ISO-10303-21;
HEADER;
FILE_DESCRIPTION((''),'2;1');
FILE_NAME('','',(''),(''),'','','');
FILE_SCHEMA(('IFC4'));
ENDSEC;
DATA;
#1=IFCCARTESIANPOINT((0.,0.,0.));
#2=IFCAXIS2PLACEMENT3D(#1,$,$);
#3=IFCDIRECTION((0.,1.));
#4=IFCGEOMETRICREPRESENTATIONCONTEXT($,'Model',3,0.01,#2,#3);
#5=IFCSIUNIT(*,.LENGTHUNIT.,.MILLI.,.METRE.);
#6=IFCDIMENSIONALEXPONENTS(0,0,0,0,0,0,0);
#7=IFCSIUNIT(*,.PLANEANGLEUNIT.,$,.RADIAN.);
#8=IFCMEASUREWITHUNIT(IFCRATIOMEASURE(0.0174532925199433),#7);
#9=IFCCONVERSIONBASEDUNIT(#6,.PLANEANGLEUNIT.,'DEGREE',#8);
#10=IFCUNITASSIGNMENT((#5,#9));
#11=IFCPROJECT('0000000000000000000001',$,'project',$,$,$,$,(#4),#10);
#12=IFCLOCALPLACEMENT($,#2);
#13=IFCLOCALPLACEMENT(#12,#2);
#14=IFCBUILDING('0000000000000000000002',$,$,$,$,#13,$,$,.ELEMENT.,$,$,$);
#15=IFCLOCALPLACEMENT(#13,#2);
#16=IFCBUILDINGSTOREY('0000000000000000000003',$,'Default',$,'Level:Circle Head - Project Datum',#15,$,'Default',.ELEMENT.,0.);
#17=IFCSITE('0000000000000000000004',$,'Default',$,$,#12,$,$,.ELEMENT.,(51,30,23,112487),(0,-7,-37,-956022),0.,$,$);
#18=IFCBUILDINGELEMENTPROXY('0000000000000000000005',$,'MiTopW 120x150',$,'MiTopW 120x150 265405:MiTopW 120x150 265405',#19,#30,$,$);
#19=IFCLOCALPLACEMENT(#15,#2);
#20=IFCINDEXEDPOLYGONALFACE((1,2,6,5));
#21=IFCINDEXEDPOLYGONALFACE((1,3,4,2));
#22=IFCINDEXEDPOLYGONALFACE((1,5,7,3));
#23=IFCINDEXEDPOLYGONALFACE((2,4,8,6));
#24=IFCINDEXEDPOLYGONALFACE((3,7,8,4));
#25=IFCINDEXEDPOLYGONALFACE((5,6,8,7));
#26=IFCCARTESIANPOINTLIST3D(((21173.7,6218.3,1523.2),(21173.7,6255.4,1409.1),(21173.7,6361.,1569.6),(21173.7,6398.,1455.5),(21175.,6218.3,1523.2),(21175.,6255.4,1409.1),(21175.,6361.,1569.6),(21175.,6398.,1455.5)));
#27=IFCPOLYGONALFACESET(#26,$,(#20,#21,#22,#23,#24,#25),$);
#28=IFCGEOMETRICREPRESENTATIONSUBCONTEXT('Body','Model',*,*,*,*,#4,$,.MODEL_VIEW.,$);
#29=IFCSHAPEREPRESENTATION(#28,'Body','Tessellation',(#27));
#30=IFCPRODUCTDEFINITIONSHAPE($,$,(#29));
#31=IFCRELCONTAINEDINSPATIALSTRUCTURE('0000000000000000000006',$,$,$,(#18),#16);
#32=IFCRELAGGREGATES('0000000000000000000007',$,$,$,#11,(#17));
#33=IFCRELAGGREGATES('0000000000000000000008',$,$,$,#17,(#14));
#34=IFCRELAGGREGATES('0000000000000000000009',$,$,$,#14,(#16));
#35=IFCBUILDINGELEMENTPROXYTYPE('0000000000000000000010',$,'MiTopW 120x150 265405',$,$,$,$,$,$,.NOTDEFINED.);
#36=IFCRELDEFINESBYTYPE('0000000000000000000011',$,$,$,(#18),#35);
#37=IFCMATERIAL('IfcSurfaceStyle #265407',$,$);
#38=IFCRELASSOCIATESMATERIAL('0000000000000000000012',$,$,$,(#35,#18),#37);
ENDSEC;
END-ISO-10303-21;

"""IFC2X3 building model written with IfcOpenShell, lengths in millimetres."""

from ifc_helpers import new_model, entity, si_unit, converted_unit, direction, frame, origin, place, context, subcontext, project, spatial, polyline, outline, extrude, source, transform, mapped, material, type_object, type_shapes, element, save


model = new_model("IFC2X3")

# Units and contexts
model_context = context("Model", 3, precision=0.01, world=origin(), true_north=direction((0.0, 1.0)))
body_context = subcontext(model_context, "Body", "Model", "MODEL_VIEW")
ifc_project = project(units=[si_unit("LENGTHUNIT", "METRE", prefix="MILLI"), converted_unit("PLANEANGLEUNIT", "DEGREE", entity("IfcRatioMeasure", 0.0174532925199433), si_unit("PLANEANGLEUNIT", "RADIAN"), dimensions=[0, 0, 0, 0, 0, 0, 0])], contexts=[model_context])

# Site, building, storey
site_placement = place(None, origin())
site = spatial("IfcSite", under=ifc_project, at=site_placement, Name="Default", CompositionType="ELEMENT", RefLatitude=(51, 30, 23, 112487), RefLongitude=(0, -7, -37, -956022), RefElevation=0.0)
building_placement = place(site_placement, origin())
building = spatial("IfcBuilding", under=site, at=building_placement, CompositionType="ELEMENT")
storey_placement = place(building_placement, origin())
storey = spatial("IfcBuildingStorey", under=building, at=storey_placement, Name="Default", ObjectType="Level:Circle Head - Project Datum", LongName="Default", CompositionType="ELEMENT", Elevation=0.0)

# Building element proxy
ifc_material_1 = material(Name="IfcSurfaceStyle #265407")
building_element_proxy_type_1 = type_object("IfcBuildingElementProxyType", Name="MiTopW 120x150 265405", PredefinedType="NOTDEFINED", material=ifc_material_1)
shared_shape_1 = source(origin(), body_context, "Body", "SweptSolid", [
    extrude(outline(polyline([(-75.0, -60.0), (75.0, -60.0), (75.0, 60.0), (-75.0, 60.0), (-75.0, -60.0)])), frame((75.0, 60.0, 0.0), z_axis=(0.0, 0.0, 1.0), x_axis=(-1.0, 0.0, 0.0)), (0.0, 0.0, 1.0), 1.3),
])
type_shapes(building_element_proxy_type_1, [shared_shape_1])
proxy_1_placement = place(building_placement, frame((21175.0, 6218.3, 1523.2), z_axis=(-1.0, 0.0, 0.0), x_axis=(0.0, 0.951057, 0.309017)))
element("IfcBuildingElementProxy", 1, at=proxy_1_placement, inside=storey, type_object=building_element_proxy_type_1, material=ifc_material_1, Name="MiTopW 120x150", ObjectType="MiTopW 120x150 265405:MiTopW 120x150 265405", context=body_context, shape_type="MappedRepresentation", body=[
    mapped(shared_shape_1, transform((0.0, 0.0, 0.0), scale=1.0)),
])

save(model, "model.ifc")
